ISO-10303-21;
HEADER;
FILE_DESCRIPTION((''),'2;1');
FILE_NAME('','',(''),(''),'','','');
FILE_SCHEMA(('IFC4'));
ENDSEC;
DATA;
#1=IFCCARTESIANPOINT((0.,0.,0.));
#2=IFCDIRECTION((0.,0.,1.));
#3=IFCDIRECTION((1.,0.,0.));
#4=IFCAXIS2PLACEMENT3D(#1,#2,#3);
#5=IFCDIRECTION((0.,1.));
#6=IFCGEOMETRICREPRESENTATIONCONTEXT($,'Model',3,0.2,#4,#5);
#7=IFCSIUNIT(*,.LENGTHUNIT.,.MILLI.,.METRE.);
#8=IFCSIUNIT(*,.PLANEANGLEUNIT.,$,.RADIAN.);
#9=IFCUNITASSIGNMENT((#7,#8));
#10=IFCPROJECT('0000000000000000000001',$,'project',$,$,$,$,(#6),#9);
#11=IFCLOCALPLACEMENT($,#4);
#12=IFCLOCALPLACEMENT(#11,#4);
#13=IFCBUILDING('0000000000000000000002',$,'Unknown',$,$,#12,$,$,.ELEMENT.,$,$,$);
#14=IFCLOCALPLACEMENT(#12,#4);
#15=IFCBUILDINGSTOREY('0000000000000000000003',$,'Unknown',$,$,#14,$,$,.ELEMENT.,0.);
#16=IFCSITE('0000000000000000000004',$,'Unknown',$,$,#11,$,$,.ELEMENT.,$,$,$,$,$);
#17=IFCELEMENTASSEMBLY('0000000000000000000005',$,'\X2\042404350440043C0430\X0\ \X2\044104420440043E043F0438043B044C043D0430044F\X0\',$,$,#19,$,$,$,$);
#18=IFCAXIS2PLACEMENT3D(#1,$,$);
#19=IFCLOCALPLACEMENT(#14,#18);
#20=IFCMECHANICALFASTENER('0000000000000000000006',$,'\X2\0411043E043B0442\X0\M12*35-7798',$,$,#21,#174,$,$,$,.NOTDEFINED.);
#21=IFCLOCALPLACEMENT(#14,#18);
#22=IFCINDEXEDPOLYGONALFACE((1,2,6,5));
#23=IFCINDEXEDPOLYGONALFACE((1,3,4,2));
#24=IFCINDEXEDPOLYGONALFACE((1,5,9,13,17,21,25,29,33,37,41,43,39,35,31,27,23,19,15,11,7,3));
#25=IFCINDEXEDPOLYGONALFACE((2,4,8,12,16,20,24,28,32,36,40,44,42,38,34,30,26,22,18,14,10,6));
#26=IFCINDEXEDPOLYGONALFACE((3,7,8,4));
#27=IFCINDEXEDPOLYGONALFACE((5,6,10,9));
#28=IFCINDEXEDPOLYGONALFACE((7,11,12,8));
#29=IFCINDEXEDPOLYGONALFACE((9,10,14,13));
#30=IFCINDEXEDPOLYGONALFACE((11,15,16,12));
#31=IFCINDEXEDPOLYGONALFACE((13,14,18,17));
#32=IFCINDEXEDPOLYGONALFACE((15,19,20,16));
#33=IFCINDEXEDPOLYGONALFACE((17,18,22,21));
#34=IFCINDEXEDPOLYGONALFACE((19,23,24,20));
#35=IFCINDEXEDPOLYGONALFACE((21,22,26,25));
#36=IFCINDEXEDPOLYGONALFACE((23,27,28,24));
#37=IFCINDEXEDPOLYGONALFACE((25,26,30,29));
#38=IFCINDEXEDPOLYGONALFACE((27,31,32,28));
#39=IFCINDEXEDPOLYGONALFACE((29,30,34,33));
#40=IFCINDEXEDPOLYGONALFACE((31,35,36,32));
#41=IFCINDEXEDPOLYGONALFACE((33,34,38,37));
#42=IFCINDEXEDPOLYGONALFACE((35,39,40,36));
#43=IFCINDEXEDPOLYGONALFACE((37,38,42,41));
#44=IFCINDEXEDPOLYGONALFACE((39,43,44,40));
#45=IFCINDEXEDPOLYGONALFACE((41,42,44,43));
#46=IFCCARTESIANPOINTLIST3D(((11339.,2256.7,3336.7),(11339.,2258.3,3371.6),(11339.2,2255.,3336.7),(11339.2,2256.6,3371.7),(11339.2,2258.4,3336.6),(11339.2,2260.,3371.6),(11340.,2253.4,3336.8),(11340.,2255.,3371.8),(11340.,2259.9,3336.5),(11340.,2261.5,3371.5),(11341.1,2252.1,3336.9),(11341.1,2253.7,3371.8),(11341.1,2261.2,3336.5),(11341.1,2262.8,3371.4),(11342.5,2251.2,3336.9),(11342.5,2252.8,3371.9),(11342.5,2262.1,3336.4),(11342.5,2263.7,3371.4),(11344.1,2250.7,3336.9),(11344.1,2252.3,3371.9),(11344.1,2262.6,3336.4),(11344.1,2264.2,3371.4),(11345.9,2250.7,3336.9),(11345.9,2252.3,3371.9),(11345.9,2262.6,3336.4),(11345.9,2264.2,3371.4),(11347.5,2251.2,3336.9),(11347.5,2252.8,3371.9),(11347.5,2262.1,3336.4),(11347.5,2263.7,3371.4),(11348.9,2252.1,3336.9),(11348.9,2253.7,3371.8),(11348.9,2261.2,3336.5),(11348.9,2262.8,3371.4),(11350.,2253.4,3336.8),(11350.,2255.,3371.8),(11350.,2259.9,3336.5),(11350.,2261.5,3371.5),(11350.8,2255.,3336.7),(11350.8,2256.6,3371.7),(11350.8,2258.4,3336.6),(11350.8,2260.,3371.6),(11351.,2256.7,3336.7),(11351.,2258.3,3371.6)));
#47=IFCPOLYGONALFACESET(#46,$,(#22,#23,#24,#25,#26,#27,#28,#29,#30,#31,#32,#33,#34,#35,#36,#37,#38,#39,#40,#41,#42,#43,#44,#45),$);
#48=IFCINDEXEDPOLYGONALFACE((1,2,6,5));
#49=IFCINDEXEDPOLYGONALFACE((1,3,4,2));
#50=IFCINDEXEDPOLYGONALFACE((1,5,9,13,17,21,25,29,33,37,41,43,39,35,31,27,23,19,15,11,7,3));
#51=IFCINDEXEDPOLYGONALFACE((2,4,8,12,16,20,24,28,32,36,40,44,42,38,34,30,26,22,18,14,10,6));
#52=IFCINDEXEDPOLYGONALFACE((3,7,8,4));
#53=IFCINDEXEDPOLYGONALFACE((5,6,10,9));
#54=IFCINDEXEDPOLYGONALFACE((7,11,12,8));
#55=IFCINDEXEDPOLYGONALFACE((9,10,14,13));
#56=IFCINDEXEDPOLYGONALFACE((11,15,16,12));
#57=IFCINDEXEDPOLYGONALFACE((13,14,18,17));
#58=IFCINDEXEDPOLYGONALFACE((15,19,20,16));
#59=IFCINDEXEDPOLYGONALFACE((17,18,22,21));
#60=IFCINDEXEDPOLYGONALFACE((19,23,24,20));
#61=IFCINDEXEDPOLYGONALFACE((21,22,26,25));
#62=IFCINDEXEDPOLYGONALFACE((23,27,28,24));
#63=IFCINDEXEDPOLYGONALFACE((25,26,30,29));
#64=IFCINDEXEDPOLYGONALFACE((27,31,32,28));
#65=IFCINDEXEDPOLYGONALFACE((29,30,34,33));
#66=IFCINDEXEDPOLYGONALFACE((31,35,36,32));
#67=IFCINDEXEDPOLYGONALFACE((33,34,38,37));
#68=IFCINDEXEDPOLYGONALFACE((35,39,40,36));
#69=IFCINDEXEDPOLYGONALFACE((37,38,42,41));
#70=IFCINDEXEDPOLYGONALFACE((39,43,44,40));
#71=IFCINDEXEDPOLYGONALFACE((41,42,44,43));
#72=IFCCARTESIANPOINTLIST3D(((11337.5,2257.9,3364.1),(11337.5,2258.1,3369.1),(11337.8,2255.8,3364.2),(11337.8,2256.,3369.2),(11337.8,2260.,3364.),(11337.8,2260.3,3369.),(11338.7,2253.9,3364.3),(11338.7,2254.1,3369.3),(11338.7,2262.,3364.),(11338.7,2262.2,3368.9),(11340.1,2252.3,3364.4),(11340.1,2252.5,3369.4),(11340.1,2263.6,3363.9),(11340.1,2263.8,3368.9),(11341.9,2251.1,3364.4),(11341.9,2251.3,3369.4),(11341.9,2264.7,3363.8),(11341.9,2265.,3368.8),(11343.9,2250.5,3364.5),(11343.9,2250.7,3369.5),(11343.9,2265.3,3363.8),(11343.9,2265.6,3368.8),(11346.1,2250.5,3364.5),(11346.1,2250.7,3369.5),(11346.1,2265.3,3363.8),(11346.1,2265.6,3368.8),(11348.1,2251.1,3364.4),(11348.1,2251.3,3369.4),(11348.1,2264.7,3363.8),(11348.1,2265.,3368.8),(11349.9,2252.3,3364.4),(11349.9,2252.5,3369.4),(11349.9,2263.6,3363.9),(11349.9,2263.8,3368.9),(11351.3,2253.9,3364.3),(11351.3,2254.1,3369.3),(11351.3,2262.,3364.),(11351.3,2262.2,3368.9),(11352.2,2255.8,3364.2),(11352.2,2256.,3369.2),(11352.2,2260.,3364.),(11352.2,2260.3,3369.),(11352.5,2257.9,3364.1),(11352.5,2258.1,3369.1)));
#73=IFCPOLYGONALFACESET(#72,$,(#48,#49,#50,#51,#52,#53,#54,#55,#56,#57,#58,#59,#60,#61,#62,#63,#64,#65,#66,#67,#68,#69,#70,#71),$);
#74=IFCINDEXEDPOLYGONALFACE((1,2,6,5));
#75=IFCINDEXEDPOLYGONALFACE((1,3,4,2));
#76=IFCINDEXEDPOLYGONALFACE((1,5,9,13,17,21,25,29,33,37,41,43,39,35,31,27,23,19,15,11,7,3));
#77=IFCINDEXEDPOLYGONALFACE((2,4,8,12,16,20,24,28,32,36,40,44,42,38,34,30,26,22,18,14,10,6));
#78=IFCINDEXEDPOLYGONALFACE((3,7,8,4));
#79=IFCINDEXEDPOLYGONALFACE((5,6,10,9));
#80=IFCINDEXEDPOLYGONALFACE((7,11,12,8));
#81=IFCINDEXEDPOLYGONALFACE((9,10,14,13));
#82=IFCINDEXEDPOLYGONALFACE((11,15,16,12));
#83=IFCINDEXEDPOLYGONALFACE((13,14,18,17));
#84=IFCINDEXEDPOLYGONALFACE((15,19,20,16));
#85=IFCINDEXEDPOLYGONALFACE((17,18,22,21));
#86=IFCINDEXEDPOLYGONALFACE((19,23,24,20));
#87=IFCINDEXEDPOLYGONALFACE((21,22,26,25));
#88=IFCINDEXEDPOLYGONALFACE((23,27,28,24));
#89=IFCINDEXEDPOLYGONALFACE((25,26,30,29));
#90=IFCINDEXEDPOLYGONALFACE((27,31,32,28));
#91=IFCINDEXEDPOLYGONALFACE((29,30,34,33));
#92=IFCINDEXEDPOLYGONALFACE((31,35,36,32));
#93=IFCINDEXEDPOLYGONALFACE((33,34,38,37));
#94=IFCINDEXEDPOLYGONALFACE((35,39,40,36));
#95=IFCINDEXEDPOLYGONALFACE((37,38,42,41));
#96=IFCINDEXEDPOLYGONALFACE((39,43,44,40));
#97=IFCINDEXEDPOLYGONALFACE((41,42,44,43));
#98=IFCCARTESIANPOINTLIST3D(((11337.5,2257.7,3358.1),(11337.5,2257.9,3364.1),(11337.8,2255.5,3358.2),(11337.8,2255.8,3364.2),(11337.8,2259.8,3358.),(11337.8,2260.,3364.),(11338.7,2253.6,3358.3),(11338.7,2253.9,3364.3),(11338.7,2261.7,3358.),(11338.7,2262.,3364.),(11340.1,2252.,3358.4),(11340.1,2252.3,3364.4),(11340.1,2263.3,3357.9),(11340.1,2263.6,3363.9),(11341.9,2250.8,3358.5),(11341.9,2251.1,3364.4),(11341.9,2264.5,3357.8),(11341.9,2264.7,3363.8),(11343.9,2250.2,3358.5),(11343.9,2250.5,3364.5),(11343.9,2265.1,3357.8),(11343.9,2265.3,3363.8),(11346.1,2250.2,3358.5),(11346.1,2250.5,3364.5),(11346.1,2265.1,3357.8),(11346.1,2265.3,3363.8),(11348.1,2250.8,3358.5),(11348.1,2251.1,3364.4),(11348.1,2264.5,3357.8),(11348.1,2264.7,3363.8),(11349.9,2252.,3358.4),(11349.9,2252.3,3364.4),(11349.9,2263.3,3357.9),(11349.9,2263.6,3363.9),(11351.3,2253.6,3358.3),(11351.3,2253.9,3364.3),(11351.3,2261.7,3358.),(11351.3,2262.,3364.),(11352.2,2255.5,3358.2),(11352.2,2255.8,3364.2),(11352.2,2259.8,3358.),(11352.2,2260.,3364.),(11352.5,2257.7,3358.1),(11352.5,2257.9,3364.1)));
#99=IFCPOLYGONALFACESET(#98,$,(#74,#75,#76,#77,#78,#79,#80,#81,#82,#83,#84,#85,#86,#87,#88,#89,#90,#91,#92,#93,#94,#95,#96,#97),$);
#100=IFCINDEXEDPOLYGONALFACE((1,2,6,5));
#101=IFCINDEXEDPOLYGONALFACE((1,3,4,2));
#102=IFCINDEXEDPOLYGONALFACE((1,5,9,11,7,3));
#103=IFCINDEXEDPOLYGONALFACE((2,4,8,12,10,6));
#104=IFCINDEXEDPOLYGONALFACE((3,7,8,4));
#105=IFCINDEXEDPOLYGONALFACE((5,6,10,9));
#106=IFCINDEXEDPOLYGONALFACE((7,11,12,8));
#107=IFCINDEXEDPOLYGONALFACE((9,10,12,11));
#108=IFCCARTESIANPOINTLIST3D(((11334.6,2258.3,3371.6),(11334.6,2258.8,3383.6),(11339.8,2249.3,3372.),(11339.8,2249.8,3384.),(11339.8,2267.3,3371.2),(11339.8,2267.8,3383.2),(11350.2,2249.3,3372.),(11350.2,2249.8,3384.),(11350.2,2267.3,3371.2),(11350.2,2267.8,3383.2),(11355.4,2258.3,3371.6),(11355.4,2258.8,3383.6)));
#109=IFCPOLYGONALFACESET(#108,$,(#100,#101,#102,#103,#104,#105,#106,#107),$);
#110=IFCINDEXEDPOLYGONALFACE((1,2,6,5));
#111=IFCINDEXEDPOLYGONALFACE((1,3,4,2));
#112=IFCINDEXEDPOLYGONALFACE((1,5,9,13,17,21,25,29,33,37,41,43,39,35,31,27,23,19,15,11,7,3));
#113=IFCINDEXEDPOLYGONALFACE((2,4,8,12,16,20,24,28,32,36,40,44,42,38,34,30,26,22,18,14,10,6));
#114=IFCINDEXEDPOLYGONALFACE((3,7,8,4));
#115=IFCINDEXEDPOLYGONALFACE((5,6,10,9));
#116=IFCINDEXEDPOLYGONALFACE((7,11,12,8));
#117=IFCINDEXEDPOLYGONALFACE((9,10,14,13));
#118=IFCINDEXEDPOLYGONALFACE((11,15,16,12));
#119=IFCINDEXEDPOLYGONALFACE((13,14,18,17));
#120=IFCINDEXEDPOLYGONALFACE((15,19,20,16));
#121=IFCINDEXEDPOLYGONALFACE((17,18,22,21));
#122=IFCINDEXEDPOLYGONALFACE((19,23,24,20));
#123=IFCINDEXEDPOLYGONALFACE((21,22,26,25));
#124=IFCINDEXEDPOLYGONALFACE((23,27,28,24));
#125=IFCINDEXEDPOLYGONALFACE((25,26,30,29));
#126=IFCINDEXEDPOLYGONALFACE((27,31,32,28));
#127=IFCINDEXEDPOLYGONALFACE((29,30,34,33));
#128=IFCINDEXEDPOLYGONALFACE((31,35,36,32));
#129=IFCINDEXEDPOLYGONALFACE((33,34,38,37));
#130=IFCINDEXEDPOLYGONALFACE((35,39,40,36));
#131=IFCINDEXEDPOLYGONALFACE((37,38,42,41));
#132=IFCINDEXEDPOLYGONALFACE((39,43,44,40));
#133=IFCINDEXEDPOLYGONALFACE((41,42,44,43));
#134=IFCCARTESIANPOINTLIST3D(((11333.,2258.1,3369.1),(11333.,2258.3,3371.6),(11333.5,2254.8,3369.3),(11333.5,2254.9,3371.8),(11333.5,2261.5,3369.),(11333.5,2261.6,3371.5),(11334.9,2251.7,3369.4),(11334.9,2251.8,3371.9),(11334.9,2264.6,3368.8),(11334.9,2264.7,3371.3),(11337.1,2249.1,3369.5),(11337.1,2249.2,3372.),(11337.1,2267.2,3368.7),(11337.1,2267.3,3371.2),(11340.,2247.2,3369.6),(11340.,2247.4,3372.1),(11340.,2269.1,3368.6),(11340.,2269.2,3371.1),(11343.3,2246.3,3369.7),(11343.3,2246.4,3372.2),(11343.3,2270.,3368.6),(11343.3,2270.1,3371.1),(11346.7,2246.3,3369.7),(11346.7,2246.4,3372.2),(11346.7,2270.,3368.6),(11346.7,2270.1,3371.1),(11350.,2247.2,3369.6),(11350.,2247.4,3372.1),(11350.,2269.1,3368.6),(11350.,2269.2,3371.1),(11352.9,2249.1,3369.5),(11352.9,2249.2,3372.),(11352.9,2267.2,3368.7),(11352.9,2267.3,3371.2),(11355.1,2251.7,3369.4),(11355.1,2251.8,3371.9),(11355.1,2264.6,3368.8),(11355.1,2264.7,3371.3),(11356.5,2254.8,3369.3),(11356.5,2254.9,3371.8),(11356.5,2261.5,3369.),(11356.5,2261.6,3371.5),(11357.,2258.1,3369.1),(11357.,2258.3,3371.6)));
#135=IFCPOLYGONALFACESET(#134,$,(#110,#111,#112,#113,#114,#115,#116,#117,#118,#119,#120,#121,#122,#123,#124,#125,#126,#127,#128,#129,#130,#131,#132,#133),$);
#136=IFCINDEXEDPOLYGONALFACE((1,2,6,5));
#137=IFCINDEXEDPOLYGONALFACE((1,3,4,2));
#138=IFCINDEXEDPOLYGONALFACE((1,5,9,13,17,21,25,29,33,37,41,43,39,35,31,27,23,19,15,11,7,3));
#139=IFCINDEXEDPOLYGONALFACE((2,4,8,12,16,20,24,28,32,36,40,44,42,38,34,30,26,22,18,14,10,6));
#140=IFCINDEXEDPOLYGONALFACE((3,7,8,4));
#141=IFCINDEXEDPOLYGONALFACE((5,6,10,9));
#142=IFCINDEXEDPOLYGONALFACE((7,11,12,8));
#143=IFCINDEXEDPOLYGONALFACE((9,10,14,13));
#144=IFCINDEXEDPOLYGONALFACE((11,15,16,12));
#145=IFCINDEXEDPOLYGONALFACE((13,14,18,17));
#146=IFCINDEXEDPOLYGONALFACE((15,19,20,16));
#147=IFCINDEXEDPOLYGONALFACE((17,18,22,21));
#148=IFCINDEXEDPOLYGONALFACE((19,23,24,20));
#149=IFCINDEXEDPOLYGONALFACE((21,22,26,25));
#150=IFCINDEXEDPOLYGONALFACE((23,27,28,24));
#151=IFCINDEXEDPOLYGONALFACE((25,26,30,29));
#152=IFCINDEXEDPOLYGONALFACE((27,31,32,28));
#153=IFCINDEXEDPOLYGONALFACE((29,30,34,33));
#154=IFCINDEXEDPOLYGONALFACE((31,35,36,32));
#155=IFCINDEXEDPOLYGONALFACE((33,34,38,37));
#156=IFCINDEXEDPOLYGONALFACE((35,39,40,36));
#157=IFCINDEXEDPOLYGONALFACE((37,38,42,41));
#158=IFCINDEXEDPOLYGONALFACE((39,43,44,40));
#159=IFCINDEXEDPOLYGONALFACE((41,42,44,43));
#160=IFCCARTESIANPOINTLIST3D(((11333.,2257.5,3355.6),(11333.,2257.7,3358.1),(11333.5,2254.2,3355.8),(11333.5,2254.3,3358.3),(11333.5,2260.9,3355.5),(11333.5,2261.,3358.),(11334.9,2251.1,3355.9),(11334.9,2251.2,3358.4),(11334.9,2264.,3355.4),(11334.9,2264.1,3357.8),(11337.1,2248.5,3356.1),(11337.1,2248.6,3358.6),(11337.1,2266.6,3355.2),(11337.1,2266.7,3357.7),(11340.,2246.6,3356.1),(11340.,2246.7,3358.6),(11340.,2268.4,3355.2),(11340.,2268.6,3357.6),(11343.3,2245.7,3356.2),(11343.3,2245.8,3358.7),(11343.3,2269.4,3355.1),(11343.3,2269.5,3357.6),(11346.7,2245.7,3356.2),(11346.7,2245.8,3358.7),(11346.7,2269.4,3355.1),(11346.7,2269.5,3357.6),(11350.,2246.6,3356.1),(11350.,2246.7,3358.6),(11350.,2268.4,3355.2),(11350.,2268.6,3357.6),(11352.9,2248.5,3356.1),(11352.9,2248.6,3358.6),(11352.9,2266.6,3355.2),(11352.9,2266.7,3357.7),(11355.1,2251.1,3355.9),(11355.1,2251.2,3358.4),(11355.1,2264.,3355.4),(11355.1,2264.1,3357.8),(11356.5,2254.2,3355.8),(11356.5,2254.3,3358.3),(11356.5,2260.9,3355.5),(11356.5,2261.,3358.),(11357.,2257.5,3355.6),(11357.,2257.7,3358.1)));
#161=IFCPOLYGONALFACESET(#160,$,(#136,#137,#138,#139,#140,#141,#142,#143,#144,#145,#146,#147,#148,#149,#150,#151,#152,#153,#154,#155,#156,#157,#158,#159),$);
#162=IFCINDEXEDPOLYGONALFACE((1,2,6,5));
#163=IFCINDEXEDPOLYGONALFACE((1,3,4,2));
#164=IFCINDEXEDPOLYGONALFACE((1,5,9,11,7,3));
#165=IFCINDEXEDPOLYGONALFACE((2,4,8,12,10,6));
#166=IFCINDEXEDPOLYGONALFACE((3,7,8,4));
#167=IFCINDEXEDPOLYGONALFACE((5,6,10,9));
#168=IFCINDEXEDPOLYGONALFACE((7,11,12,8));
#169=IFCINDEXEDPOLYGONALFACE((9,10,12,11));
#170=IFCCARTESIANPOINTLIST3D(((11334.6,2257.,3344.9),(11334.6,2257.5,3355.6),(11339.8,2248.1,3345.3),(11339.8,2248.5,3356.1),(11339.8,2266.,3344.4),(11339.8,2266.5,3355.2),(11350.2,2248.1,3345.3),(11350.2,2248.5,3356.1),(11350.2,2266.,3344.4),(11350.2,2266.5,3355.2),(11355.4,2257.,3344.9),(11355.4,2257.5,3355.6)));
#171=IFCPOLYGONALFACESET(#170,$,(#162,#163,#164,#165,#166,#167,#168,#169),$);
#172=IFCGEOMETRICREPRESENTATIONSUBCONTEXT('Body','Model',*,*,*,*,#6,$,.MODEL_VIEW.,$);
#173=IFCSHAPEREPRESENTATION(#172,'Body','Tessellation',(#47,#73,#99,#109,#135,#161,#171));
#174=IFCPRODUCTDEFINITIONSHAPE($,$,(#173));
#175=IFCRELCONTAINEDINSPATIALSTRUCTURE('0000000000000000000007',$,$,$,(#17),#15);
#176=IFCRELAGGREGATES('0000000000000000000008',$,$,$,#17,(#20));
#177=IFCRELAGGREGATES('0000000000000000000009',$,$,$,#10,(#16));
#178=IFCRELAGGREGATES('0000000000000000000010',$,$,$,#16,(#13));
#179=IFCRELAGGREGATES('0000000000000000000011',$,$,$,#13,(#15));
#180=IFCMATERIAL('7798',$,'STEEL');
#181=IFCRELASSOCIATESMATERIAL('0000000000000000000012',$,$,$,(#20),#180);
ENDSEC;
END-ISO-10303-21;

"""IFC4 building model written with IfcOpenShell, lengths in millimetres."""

from ifc_helpers import new_model, si_unit, direction, frame, origin_with_axes, place, context, subcontext, project, spatial, line, arc, indexed_curve, outline, extrude, source, transform, mapped, material, element, aggregate, save


model = new_model("IFC4")

# Units and contexts
model_context = context("Model", 3, precision=0.2, world=origin_with_axes(), true_north=direction((0.0, 1.0)))
body_context = subcontext(model_context, "Body", "Model", "MODEL_VIEW")
ifc_project = project(units=[si_unit("LENGTHUNIT", "METRE", prefix="MILLI"), si_unit("PLANEANGLEUNIT", "RADIAN")], contexts=[model_context])

# Site, building, storey
site_placement = place(None, origin_with_axes())
site = spatial("IfcSite", under=ifc_project, at=site_placement, Name="Unknown", CompositionType="ELEMENT")
building_placement = place(site_placement, origin_with_axes())
building = spatial("IfcBuilding", under=site, at=building_placement, Name="Unknown", CompositionType="ELEMENT")
storey_placement = place(building_placement, origin_with_axes())
storey = spatial("IfcBuildingStorey", under=building, at=storey_placement, Name="Unknown", CompositionType="ELEMENT", Elevation=0.0)

# Element assembly
assembly_1_placement = place(storey_placement, frame((11400.0, 88.6, 3426.7), z_axis=(1.0, 0.0, 0.0), x_axis=(0.0, 0.998969, -0.045408)))
assembly_1 = element("IfcElementAssembly", 1, at=assembly_1_placement, inside=storey, Name="Ферма стропильная")

# Mechanical fastener
ifc_material_1 = material(Name="7798", Category="STEEL")
shared_shape_1 = source(origin_with_axes(), body_context, "Body", "SweptSolid", [
    extrude(outline(indexed_curve([(6.0, 0.0), (0.0, 6.0), (-6.0, 0.0), (0.0, -6.0)], segments=[arc(1, 2, 3), arc(3, 4, 1)])), frame((0.0, 0.0, 7.5), z_axis=(0.0, 0.0, -1.0), x_axis=(0.0, 1.0, 0.0)), (0.0, 0.0, 1.0), 35.0),
    extrude(outline(indexed_curve([(7.5, 0.0), (0.0, 7.5), (-7.5, 0.0), (0.0, -7.5)], segments=[arc(1, 2, 3), arc(3, 4, 1)])), frame((0.0, 0.0, 5.0), z_axis=(0.0, 0.0, -1.0), x_axis=(0.0, 1.0, 0.0)), (0.0, 0.0, 1.0), 5.0),
    extrude(outline(indexed_curve([(7.5, 0.0), (0.0, 7.5), (-7.5, 0.0), (0.0, -7.5)], segments=[arc(1, 2, 3), arc(3, 4, 1)])), frame((0.0, 0.0, 0.0), z_axis=(0.0, 0.0, -1.0), x_axis=(0.0, 1.0, 0.0)), (0.0, 0.0, 1.0), 6.0),
    extrude(outline(indexed_curve([(10.4, 0.0), (5.2, 9.0), (-5.2, 9.0), (-10.4, 0.0), (-5.2, -9.0), (5.2, -9.0)], segments=[line(1, 2, 3, 4, 5, 6, 1)])), frame((0.0, 0.0, 19.5), z_axis=(0.0, 0.0, -1.0), x_axis=(0.0, 1.0, 0.0)), (0.0, 0.0, 1.0), 12.0),
    extrude(outline(indexed_curve([(12.0, 0.0), (0.0, 12.0), (-12.0, 0.0), (0.0, -12.0)], segments=[arc(1, 2, 3), arc(3, 4, 1)])), frame((0.0, 0.0, 7.5), z_axis=(0.0, 0.0, -1.0), x_axis=(0.0, 1.0, 0.0)), (0.0, 0.0, 1.0), 2.5),
    extrude(outline(indexed_curve([(12.0, 0.0), (0.0, 12.0), (-12.0, 0.0), (0.0, -12.0)], segments=[arc(1, 2, 3), arc(3, 4, 1)])), frame((0.0, 0.0, -6.0), z_axis=(0.0, 0.0, -1.0), x_axis=(0.0, 1.0, 0.0)), (0.0, 0.0, 1.0), 2.5),
    extrude(outline(indexed_curve([(10.4, 0.0), (5.2, 9.0), (-5.2, 9.0), (-10.4, 0.0), (-5.2, -9.0), (5.2, -9.0)], segments=[line(1, 2, 3, 4, 5, 6, 1)])), frame((0.0, 0.0, -8.5), z_axis=(0.0, 0.0, -1.0), x_axis=(0.0, 1.0, 0.0)), (0.0, 0.0, 1.0), 10.8),
])
mechanical_fastener_1_placement = place(assembly_1_placement, frame((2169.9, 36.0, -55.0), z_axis=(0.0, 1.0, 0.0), x_axis=(-1.0, 0.0, 0.0)))
mechanical_fastener_1 = element("IfcMechanicalFastener", 2, at=mechanical_fastener_1_placement, material=ifc_material_1, Name="БолтM12*35-7798", PredefinedType="NOTDEFINED", context=body_context, shape_type="MappedRepresentation", body=[
    mapped(shared_shape_1, transform((0.0, 0.0, 0.0))),
])
aggregate(assembly_1, [mechanical_fastener_1])

save(model, "model.ifc")
